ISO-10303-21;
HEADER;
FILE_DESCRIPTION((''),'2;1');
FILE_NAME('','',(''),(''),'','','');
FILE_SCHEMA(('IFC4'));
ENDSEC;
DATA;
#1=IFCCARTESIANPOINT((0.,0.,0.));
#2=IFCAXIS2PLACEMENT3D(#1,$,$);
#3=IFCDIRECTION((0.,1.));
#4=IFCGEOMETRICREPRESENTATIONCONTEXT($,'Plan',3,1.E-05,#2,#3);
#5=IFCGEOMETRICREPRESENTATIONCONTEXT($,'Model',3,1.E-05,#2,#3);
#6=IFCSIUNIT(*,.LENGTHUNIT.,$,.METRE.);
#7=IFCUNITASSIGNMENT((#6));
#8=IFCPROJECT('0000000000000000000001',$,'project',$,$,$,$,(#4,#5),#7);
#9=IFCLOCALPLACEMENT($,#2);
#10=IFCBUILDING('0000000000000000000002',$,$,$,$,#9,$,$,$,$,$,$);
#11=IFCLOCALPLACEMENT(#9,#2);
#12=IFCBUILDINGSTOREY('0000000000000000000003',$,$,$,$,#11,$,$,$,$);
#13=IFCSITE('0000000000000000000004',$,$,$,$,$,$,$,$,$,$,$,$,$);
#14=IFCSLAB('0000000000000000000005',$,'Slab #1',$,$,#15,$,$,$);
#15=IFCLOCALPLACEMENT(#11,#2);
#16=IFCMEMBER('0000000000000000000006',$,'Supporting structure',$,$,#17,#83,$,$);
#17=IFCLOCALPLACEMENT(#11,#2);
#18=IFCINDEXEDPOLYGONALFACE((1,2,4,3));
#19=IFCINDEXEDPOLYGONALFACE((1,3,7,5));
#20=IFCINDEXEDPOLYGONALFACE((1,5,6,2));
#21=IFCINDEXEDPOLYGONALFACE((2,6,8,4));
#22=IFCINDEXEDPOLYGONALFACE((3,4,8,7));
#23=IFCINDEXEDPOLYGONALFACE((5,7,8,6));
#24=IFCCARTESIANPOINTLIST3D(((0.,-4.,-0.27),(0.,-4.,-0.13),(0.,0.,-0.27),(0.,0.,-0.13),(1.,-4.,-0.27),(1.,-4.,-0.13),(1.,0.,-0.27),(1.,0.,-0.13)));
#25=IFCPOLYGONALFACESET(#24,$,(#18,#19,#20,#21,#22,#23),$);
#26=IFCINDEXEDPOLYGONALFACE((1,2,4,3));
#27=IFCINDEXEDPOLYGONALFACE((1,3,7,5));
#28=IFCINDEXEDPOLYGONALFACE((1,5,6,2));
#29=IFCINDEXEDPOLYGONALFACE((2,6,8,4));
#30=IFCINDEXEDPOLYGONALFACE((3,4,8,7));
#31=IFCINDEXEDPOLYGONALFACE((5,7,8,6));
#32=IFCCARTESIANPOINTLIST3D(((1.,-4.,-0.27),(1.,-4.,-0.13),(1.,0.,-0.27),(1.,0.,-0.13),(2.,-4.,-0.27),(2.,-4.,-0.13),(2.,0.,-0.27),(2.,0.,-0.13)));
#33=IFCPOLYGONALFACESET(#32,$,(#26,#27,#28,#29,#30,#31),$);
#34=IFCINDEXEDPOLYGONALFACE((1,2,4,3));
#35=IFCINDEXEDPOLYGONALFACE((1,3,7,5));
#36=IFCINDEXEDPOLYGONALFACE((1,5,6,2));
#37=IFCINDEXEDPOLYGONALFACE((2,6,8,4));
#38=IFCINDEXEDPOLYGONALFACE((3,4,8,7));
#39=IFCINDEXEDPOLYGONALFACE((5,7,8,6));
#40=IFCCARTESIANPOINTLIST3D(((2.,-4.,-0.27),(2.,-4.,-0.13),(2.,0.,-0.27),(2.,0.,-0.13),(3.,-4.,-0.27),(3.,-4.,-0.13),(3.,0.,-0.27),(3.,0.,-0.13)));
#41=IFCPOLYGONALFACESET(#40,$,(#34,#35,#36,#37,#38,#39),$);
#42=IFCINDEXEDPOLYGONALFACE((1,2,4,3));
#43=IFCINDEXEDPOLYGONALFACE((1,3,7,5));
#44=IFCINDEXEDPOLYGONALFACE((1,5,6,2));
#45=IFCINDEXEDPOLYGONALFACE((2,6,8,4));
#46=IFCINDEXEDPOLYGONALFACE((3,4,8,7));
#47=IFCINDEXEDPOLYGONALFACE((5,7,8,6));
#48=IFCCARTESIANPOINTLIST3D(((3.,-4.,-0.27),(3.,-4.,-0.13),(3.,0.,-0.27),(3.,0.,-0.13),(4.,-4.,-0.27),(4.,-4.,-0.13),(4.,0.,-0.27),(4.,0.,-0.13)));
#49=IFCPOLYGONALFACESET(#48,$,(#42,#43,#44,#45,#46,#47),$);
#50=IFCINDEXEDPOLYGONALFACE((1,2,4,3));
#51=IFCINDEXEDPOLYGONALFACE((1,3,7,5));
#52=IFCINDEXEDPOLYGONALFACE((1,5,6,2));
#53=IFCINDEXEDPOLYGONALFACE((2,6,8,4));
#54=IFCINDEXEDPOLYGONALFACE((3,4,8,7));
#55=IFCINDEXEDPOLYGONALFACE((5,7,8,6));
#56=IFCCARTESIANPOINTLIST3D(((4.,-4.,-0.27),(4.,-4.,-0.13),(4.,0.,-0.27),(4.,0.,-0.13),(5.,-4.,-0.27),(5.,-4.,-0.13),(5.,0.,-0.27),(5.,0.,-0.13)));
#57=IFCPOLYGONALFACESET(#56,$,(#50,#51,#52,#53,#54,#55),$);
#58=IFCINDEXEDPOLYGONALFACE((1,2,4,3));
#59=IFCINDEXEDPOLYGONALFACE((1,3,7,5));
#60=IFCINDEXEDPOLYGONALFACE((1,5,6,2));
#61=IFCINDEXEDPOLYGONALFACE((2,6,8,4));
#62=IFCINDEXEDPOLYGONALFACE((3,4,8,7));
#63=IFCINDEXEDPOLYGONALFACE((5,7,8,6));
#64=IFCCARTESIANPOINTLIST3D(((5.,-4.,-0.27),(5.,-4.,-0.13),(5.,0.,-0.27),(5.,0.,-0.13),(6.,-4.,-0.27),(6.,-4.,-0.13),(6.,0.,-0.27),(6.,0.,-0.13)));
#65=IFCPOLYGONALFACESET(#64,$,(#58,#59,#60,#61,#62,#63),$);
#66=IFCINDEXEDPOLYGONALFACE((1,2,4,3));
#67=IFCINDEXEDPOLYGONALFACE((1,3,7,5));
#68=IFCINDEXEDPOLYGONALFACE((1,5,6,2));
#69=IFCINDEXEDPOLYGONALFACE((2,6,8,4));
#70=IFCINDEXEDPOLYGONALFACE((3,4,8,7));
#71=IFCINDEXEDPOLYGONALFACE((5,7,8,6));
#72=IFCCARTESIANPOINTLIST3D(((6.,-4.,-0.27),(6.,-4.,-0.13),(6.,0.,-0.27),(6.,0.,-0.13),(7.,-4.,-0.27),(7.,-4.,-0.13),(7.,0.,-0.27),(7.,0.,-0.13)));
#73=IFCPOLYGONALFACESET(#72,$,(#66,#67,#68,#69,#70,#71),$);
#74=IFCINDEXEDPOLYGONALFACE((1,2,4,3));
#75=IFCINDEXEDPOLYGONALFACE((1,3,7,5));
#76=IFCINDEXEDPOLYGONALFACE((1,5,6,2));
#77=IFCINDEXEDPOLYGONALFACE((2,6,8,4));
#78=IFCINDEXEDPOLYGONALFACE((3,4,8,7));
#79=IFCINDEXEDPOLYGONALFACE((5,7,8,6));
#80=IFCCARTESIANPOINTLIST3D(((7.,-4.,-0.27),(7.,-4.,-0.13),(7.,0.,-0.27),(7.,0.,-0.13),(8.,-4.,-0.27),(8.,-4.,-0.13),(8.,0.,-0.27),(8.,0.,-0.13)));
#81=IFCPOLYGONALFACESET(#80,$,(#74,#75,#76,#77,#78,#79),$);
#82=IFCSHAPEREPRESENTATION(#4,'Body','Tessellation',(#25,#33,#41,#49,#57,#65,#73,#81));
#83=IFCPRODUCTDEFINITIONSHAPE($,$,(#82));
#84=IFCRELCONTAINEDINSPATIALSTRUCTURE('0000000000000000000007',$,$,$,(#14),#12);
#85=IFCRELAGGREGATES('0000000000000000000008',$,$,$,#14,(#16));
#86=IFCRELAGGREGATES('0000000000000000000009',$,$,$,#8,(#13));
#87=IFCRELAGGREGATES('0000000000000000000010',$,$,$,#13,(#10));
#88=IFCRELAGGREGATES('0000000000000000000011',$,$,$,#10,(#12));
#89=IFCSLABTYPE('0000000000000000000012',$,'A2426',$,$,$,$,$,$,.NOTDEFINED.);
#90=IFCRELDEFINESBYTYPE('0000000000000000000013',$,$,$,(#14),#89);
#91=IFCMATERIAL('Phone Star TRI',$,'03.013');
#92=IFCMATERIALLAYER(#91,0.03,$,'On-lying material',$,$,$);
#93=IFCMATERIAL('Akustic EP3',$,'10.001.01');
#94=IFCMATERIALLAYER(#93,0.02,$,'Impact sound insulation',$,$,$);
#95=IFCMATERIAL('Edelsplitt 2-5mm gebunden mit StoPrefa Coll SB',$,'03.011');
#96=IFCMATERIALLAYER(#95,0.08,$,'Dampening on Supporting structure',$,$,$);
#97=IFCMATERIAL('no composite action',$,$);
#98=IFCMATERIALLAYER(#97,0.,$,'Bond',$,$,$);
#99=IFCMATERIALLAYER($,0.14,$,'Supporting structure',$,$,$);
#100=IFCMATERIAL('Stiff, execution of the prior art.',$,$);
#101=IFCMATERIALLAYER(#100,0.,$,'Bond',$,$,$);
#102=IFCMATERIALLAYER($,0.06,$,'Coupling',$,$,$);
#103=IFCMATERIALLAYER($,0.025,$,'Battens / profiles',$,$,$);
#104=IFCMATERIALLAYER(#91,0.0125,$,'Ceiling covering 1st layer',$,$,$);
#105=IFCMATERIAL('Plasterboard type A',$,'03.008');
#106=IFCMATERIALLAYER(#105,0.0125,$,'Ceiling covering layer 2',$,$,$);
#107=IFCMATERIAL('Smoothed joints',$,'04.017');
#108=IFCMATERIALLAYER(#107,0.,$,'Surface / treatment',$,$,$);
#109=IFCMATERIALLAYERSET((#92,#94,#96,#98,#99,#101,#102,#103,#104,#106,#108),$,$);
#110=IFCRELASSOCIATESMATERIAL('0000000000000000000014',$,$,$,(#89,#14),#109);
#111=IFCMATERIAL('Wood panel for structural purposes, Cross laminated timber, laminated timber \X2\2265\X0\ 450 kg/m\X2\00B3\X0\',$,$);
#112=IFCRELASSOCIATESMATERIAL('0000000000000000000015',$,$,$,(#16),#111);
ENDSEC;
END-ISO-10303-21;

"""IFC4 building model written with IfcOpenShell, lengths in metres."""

from ifc_helpers import new_model, si_unit, direction, frame, frame_2d, origin, place, context, project, spatial, rectangle, extrude, material, layer, layer_set, type_object, element, aggregate, save


model = new_model("IFC4")

# Units and contexts
plan_context = context("Plan", 3, precision=1e-05, world=origin(), true_north=direction((0.0, 1.0)))
model_context = context("Model", 3, precision=1e-05, world=origin(), true_north=direction((0.0, 1.0)))
ifc_project = project(units=[si_unit("LENGTHUNIT", "METRE")], contexts=[plan_context, model_context])

# Site, building, storey
site = spatial("IfcSite", under=ifc_project)
building_placement = place(None, origin())
building = spatial("IfcBuilding", under=site, at=building_placement)
storey_placement = place(building_placement, origin())
storey = spatial("IfcBuildingStorey", under=building, at=storey_placement)

# Slab, member
ifc_material_1 = material(Name="Phone Star TRI", Category="03.013")
ifc_layer_1 = layer(ifc_material_1, 0.03, Name="On-lying material")
ifc_material_2 = material(Name="Akustic EP3", Category="10.001.01")
ifc_layer_2 = layer(ifc_material_2, 0.02, Name="Impact sound insulation")
ifc_material_3 = material(Name="Edelsplitt 2-5mm gebunden mit StoPrefa Coll SB", Category="03.011")
ifc_layer_3 = layer(ifc_material_3, 0.08, Name="Dampening on Supporting structure")
ifc_material_4 = material(Name="no composite action")
ifc_layer_4 = layer(ifc_material_4, 0.0, Name="Bond")
ifc_layer_5 = layer(None, 0.14, Name="Supporting structure")
ifc_material_5 = material(Name="Stiff, execution of the prior art.")
ifc_layer_6 = layer(ifc_material_5, 0.0, Name="Bond")
ifc_layer_7 = layer(None, 0.06, Name="Coupling")
ifc_layer_8 = layer(None, 0.025, Name="Battens / profiles")
ifc_layer_9 = layer(ifc_material_1, 0.0125, Name="Ceiling covering 1st layer")
ifc_material_6 = material(Name="Plasterboard type A", Category="03.008")
ifc_layer_10 = layer(ifc_material_6, 0.0125, Name="Ceiling covering layer 2")
ifc_material_7 = material(Name="Smoothed joints", Category="04.017")
ifc_layer_11 = layer(ifc_material_7, 0.0, Name="Surface / treatment")
ifc_layer_set = layer_set([ifc_layer_1, ifc_layer_2, ifc_layer_3, ifc_layer_4, ifc_layer_5, ifc_layer_6, ifc_layer_7, ifc_layer_8, ifc_layer_9, ifc_layer_10, ifc_layer_11])
slab_type = type_object("IfcSlabType", Name="A2426", PredefinedType="NOTDEFINED", material=ifc_layer_set)
slab_placement = place(None, frame((0.0, 0.0, 0.0), z_axis=(0.0, 0.0, -1.0), x_axis=(1.0, 0.0, 0.0)))
slab = element("IfcSlab", 1, at=slab_placement, inside=storey, type_object=slab_type, material=ifc_layer_set, Name="Slab #1")
ifc_material_8 = material(Name="Wood panel for structural purposes, Cross laminated timber, laminated timber ≥ 450 kg/m³")
member_1_placement = place(slab_placement, origin())
member_1 = element("IfcMember", 2, at=member_1_placement, material=ifc_material_8, Name="Supporting structure", context=plan_context, shape_type="SweptSolid", body=[
    extrude(rectangle(XDim=1.0, YDim=0.14, at=frame_2d((0.5, 0.07), x_axis=(1.0, 0.0))), frame((0.0, 4.0, 0.13), z_axis=(0.0, -1.0, 0.0), x_axis=(1.0, 0.0, 0.0)), (0.0, 0.0, 1.0), 4.0),
    extrude(rectangle(XDim=1.0, YDim=0.14, at=frame_2d((0.5, 0.07), x_axis=(1.0, 0.0))), frame((1.0, 4.0, 0.13), z_axis=(0.0, -1.0, 0.0), x_axis=(1.0, 0.0, 0.0)), (0.0, 0.0, 1.0), 4.0),
    extrude(rectangle(XDim=1.0, YDim=0.14, at=frame_2d((0.5, 0.07), x_axis=(1.0, 0.0))), frame((2.0, 4.0, 0.13), z_axis=(0.0, -1.0, 0.0), x_axis=(1.0, 0.0, 0.0)), (0.0, 0.0, 1.0), 4.0),
    extrude(rectangle(XDim=1.0, YDim=0.14, at=frame_2d((0.5, 0.07), x_axis=(1.0, 0.0))), frame((3.0, 4.0, 0.13), z_axis=(0.0, -1.0, 0.0), x_axis=(1.0, 0.0, 0.0)), (0.0, 0.0, 1.0), 4.0),
    extrude(rectangle(XDim=1.0, YDim=0.14, at=frame_2d((0.5, 0.07), x_axis=(1.0, 0.0))), frame((4.0, 4.0, 0.13), z_axis=(0.0, -1.0, 0.0), x_axis=(1.0, 0.0, 0.0)), (0.0, 0.0, 1.0), 4.0),
    extrude(rectangle(XDim=1.0, YDim=0.14, at=frame_2d((0.5, 0.07), x_axis=(1.0, 0.0))), frame((5.0, 4.0, 0.13), z_axis=(0.0, -1.0, 0.0), x_axis=(1.0, 0.0, 0.0)), (0.0, 0.0, 1.0), 4.0),
    extrude(rectangle(XDim=1.0, YDim=0.14, at=frame_2d((0.5, 0.07), x_axis=(1.0, 0.0))), frame((6.0, 4.0, 0.13), z_axis=(0.0, -1.0, 0.0), x_axis=(1.0, 0.0, 0.0)), (0.0, 0.0, 1.0), 4.0),
    extrude(rectangle(XDim=1.0, YDim=0.14, at=frame_2d((0.5, 0.07), x_axis=(1.0, 0.0))), frame((7.0, 4.0, 0.13), z_axis=(0.0, -1.0, 0.0), x_axis=(1.0, 0.0, 0.0)), (0.0, 0.0, 1.0), 4.0),
])
aggregate(slab, [member_1])

save(model, "model.ifc")
